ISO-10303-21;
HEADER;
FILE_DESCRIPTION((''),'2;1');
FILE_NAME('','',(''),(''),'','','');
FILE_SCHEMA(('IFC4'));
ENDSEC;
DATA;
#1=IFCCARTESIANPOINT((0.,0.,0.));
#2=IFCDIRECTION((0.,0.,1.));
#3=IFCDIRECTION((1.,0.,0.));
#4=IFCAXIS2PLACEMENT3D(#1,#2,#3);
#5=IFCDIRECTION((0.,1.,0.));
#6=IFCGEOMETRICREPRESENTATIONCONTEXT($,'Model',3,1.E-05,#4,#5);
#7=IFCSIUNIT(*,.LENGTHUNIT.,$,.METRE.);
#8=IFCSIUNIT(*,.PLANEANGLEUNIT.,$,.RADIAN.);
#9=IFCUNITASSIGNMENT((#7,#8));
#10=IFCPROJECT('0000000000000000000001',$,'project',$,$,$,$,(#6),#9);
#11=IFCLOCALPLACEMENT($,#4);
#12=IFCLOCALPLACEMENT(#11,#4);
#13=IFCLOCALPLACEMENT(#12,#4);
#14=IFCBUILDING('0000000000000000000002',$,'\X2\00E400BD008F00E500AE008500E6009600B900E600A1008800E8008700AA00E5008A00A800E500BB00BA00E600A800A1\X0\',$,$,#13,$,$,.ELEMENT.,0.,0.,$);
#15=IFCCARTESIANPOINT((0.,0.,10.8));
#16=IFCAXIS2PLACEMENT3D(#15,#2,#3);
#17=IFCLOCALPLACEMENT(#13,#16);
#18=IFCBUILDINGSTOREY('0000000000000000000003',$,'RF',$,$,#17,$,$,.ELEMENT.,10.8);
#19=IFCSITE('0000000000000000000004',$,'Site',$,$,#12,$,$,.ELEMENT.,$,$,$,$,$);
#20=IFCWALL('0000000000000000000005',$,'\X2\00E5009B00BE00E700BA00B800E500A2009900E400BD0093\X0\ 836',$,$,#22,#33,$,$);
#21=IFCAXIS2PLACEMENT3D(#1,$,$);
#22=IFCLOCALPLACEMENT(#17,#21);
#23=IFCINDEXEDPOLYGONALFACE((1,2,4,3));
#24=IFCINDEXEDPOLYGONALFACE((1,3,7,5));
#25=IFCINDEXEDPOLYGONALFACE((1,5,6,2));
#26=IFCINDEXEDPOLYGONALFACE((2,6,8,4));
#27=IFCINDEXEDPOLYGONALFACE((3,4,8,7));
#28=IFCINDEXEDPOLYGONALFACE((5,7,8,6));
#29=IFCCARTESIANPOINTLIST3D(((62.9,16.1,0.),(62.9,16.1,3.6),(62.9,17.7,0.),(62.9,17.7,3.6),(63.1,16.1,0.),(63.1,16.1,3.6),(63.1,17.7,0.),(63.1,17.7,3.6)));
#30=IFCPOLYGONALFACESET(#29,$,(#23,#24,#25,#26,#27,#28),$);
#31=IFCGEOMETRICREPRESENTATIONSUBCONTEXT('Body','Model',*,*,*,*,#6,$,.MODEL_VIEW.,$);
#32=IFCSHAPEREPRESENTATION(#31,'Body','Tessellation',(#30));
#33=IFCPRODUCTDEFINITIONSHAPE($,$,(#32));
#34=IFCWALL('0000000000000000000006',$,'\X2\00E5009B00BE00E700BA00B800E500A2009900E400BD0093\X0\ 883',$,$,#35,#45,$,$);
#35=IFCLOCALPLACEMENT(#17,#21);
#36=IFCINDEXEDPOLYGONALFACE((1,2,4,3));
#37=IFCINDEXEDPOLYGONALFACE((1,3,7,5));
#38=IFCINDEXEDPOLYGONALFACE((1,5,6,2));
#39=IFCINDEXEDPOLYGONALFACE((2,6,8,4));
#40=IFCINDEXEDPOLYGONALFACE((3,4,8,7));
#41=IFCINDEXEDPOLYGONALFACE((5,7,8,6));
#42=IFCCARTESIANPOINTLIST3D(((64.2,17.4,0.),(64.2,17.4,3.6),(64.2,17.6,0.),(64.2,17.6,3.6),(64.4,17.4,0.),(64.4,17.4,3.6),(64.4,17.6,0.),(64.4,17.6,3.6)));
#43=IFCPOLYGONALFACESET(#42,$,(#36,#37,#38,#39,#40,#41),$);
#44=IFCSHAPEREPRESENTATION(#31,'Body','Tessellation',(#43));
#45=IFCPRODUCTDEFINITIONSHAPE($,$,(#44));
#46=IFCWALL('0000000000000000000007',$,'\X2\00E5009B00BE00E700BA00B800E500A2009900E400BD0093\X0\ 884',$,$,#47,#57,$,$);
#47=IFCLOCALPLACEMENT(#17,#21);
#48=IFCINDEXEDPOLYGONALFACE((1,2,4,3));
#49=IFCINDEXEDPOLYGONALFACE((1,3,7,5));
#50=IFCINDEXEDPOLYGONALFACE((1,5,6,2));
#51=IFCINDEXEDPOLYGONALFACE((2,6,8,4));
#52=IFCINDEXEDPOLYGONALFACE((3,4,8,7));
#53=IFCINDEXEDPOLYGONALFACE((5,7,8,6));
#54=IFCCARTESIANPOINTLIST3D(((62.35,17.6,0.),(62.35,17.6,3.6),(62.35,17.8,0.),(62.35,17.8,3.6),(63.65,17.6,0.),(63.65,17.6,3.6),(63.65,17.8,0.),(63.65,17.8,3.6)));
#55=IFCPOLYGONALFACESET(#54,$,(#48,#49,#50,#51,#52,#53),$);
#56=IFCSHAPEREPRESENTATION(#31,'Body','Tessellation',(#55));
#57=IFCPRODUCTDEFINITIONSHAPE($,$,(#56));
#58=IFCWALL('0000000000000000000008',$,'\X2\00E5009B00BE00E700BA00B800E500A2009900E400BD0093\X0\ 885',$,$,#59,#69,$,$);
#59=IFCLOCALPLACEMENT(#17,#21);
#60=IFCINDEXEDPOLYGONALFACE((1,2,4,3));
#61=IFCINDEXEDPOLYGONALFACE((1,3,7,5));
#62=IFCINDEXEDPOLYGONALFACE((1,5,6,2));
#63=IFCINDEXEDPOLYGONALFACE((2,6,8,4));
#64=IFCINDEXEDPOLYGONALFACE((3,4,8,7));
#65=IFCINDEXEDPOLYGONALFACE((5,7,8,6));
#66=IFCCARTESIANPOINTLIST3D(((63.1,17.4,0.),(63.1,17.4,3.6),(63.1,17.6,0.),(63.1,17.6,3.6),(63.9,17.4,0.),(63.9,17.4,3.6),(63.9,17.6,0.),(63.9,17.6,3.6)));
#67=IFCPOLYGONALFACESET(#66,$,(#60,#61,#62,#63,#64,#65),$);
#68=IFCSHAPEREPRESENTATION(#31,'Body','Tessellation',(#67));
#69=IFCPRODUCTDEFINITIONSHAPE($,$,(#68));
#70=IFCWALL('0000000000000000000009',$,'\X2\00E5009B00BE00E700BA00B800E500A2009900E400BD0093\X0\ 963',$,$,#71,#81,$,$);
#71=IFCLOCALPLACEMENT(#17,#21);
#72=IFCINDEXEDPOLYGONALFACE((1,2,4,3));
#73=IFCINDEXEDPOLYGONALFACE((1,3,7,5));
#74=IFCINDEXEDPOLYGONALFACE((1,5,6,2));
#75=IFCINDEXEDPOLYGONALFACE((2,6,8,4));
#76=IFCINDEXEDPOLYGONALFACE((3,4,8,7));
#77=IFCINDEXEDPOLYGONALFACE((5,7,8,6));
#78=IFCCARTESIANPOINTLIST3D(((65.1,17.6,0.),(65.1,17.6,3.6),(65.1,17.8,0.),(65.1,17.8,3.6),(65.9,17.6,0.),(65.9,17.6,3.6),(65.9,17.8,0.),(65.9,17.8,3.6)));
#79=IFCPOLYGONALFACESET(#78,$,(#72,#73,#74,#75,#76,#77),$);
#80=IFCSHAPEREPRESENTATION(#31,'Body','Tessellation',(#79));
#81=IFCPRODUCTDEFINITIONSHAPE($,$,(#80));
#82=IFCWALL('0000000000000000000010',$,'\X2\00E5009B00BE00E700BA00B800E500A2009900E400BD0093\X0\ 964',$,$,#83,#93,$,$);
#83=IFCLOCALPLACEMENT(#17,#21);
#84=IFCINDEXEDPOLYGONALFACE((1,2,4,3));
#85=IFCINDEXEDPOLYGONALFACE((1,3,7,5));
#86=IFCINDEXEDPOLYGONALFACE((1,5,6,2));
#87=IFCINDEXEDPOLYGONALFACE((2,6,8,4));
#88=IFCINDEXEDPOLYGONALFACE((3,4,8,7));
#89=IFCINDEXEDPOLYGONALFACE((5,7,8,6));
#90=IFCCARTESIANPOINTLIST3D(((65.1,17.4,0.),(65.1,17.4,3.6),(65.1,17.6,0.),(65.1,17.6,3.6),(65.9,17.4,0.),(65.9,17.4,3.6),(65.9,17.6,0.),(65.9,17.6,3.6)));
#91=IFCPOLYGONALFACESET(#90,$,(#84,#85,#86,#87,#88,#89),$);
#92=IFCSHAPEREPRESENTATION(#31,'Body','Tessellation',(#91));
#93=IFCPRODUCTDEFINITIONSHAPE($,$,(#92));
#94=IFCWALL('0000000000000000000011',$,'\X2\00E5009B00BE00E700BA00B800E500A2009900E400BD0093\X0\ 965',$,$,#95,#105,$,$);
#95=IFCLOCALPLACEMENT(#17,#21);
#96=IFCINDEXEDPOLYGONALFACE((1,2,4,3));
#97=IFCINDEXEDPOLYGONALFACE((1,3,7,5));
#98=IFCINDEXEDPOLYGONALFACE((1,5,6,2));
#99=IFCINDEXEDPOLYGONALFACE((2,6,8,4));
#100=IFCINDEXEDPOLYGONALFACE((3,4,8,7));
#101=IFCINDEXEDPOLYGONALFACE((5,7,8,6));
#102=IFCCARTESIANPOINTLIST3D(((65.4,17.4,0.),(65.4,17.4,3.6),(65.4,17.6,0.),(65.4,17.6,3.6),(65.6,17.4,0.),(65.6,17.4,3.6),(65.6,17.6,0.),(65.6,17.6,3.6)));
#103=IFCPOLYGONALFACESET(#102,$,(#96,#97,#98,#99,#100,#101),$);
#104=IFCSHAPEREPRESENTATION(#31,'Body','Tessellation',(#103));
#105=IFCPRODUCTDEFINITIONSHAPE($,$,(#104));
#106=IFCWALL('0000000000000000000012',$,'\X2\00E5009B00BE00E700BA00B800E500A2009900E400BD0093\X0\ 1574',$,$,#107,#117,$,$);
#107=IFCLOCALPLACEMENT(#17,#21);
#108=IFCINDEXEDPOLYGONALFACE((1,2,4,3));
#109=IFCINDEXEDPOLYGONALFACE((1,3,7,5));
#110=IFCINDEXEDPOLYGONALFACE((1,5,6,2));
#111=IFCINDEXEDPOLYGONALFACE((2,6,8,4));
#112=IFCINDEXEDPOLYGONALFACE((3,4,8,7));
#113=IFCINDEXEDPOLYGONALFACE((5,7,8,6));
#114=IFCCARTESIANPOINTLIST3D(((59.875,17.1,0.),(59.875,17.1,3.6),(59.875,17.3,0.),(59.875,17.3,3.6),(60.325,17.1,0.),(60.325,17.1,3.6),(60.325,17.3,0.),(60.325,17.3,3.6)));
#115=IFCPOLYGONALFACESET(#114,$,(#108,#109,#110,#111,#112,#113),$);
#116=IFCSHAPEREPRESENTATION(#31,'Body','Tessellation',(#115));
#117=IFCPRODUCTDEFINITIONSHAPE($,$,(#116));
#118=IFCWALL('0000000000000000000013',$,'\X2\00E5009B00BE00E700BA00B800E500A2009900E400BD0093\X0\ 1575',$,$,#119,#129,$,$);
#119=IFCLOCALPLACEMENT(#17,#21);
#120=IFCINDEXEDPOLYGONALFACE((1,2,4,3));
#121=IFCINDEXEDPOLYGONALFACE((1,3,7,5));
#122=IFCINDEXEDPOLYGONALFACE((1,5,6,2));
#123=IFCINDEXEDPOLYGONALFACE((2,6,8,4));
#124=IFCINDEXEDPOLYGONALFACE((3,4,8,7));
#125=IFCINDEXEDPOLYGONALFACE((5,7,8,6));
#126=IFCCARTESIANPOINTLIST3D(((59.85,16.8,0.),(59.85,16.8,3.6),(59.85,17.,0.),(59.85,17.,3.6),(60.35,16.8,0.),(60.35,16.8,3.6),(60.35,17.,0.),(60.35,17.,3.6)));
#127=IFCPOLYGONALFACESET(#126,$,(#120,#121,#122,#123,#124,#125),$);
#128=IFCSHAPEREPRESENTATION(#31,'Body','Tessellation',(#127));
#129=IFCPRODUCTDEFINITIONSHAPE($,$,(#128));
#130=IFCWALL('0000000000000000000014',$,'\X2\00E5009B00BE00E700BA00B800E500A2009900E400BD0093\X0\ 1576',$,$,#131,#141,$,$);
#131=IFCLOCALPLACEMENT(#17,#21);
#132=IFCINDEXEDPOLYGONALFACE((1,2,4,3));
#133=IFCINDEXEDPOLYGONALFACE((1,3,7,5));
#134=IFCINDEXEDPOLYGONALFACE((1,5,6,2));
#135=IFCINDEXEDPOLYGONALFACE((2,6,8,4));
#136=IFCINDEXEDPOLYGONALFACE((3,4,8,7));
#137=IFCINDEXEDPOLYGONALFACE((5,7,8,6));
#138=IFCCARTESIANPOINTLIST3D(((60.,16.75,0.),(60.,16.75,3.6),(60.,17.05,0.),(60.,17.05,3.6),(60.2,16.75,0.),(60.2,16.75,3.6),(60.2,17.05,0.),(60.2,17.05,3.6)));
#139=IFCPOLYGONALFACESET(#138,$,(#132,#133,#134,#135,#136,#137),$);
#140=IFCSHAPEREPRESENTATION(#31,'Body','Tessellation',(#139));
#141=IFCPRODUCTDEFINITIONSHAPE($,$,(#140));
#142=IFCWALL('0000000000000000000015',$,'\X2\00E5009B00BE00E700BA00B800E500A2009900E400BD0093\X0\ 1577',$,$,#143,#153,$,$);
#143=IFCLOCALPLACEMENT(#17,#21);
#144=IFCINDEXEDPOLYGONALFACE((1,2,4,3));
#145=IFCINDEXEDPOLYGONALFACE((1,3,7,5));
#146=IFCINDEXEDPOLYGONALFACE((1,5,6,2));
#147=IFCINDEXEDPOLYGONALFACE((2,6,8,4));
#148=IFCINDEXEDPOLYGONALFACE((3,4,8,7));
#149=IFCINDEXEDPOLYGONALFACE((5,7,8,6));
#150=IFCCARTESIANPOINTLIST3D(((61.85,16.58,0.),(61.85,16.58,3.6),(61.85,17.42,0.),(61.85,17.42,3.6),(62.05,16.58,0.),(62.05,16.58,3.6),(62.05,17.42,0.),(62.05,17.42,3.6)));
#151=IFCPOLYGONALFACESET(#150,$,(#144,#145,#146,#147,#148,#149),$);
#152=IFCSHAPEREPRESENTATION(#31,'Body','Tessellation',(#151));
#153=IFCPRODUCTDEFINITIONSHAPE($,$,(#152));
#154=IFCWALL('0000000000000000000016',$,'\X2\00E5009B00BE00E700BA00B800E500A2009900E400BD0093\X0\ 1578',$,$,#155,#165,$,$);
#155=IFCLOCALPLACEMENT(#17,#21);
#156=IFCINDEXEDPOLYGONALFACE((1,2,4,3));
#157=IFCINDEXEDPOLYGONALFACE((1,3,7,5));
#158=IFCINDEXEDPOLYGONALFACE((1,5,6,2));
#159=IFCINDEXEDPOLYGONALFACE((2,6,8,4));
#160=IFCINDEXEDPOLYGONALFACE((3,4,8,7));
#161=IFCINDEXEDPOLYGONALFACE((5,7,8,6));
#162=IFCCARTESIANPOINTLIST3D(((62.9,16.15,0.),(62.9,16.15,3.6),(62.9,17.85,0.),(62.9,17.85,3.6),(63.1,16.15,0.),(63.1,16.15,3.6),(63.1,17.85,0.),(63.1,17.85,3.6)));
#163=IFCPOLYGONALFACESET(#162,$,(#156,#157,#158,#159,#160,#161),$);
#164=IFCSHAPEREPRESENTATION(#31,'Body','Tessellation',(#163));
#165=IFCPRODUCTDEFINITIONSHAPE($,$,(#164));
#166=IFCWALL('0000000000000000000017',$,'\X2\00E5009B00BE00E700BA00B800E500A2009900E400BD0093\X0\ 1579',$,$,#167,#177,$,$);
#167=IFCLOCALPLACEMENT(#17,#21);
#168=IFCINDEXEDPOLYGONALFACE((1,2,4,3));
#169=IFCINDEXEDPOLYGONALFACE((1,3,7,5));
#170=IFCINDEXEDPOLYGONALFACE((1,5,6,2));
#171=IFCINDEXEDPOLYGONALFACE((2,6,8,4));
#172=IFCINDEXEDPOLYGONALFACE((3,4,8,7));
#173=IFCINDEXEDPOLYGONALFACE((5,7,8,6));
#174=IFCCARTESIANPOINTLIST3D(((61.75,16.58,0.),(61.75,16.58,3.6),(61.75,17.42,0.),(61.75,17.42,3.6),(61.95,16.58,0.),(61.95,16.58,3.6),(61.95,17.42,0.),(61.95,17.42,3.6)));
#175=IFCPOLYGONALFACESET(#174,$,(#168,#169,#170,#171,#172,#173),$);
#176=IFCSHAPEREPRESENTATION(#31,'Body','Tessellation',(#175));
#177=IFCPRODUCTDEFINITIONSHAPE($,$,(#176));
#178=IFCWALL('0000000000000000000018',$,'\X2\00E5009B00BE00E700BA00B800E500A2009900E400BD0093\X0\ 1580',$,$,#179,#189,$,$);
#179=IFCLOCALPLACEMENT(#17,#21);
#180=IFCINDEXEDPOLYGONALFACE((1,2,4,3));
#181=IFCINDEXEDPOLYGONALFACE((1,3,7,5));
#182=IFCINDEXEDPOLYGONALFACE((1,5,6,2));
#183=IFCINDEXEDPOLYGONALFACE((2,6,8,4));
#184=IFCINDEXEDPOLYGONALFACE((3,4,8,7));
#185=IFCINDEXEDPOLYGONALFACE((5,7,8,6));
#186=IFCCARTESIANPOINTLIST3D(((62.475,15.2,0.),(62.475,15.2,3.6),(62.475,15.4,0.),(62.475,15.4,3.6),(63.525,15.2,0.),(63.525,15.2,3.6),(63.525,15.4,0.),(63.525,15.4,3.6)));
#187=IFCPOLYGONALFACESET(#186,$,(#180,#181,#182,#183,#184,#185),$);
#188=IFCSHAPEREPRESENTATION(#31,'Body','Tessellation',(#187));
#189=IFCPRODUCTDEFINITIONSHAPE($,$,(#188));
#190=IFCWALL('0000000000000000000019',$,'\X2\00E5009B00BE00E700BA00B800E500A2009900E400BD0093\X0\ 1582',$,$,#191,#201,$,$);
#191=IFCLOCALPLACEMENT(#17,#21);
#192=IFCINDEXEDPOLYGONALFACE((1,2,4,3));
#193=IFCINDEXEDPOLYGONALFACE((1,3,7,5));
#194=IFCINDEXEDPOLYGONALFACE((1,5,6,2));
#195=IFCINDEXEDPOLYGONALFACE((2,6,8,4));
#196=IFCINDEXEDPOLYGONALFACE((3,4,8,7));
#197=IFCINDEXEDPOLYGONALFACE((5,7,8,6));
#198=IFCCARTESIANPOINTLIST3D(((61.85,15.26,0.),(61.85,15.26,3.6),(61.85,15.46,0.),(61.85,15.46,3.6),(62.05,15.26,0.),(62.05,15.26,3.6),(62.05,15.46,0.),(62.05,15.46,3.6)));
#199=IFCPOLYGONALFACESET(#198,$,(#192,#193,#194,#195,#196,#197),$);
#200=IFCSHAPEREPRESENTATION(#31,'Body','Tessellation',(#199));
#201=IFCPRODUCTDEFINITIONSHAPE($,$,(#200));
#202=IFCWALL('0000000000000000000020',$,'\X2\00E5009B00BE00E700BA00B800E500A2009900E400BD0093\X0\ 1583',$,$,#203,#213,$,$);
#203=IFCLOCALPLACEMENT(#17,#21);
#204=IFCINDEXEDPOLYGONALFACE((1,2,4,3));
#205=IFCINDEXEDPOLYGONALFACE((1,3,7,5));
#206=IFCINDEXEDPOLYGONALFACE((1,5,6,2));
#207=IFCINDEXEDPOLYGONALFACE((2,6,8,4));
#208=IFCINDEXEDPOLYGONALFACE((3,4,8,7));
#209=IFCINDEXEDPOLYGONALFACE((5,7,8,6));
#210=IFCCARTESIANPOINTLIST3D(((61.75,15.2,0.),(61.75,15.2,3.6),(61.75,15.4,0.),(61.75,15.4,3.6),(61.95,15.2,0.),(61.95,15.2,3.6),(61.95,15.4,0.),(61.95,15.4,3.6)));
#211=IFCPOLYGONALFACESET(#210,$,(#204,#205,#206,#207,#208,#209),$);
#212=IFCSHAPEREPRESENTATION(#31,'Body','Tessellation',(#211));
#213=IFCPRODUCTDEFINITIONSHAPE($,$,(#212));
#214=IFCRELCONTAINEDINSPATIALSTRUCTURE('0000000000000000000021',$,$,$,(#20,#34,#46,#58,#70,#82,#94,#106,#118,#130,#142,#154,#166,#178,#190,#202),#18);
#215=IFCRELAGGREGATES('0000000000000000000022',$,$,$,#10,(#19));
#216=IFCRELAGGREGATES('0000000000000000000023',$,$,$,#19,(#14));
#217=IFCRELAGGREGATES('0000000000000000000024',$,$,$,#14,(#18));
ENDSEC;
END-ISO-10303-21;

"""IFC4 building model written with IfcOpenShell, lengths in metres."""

from ifc_helpers import new_model, si_unit, direction, frame, frame_2d, origin_with_axes, place, context, subcontext, project, spatial, rectangle, extrude, element, save


model = new_model("IFC4")

# Units and contexts
model_context = context("Model", 3, precision=1e-05, world=origin_with_axes(), true_north=direction((0.0, 1.0, 0.0)))
body_context = subcontext(model_context, "Body", "Model", "MODEL_VIEW")
ifc_project = project(units=[si_unit("LENGTHUNIT", "METRE"), si_unit("PLANEANGLEUNIT", "RADIAN")], contexts=[model_context])

# Site, building, storey
placement = place(None, origin_with_axes())
site_placement = place(placement, origin_with_axes())
site = spatial("IfcSite", under=ifc_project, at=site_placement, Name="Site", CompositionType="ELEMENT")
building_placement = place(site_placement, origin_with_axes())
building = spatial("IfcBuilding", under=site, at=building_placement, Name="ä½\u008få®\u0085æ\u0096¹æ¡\u0088è\u0087ªå\u008a¨å»ºæ¨¡", CompositionType="ELEMENT", ElevationOfRefHeight=0.0, ElevationOfTerrain=0.0)
storey_placement = place(building_placement, frame((0.0, 0.0, 10.8), z_axis=(0.0, 0.0, 1.0), x_axis=(1.0, 0.0, 0.0)))
storey = spatial("IfcBuildingStorey", under=building, at=storey_placement, Name="RF", CompositionType="ELEMENT", Elevation=10.8)

# Walls
wall_1_placement = place(storey_placement, frame((63.0, 16.9, 0.0), z_axis=(0.0, 0.0, 1.0), x_axis=(0.0, -1.0, 0.0)))
element("IfcWall", 1, at=wall_1_placement, inside=storey, Name="å\u009b¾çº¸å¢\u0099ä½\u0093 836", context=body_context, shape_type="SweptSolid", body=[
    extrude(rectangle(XDim=1.6, YDim=0.2, at=frame_2d((0.0, 0.0), x_axis=(1.0, 0.0, 0.0))), frame((0.0, 0.0, 0.0), z_axis=(0.0, 0.0, 1.0)), (0.0, 0.0, 1.0), 3.6),
])
wall_2_placement = place(storey_placement, frame((64.3, 17.5, 0.0), z_axis=(0.0, 0.0, 1.0), x_axis=(0.0, 1.0, 0.0)))
element("IfcWall", 2, at=wall_2_placement, inside=storey, Name="å\u009b¾çº¸å¢\u0099ä½\u0093 883", context=body_context, shape_type="SweptSolid", body=[
    extrude(rectangle(XDim=0.2, YDim=0.2, at=frame_2d((0.0, 0.0), x_axis=(1.0, 0.0, 0.0))), frame((0.0, 0.0, 0.0), z_axis=(0.0, 0.0, 1.0)), (0.0, 0.0, 1.0), 3.6),
])
wall_3_placement = place(storey_placement, frame((63.0, 17.7, 0.0), z_axis=(0.0, 0.0, 1.0), x_axis=(1.0, 0.0, 0.0)))
element("IfcWall", 3, at=wall_3_placement, inside=storey, Name="å\u009b¾çº¸å¢\u0099ä½\u0093 884", context=body_context, shape_type="SweptSolid", body=[
    extrude(rectangle(XDim=1.3, YDim=0.2, at=frame_2d((0.0, 0.0), x_axis=(1.0, 0.0, 0.0))), frame((0.0, 0.0, 0.0), z_axis=(0.0, 0.0, 1.0)), (0.0, 0.0, 1.0), 3.6),
])
for number, where, z_axis, x_axis, name in (
    (4, (63.5, 17.5, 0.0), (0.0, 0.0, 1.0), (1.0, 0.0, 0.0), "å\u009b¾çº¸å¢\u0099ä½\u0093 885"),
    (5, (65.5, 17.7, 0.0), (0.0, 0.0, 1.0), (1.0, 0.0, 0.0), "å\u009b¾çº¸å¢\u0099ä½\u0093 963"),
    (6, (65.5, 17.5, 0.0), (0.0, 0.0, 1.0), (1.0, 0.0, 0.0), "å\u009b¾çº¸å¢\u0099ä½\u0093 964"),
):
    element("IfcWall", number, at=place(storey_placement, frame(where, z_axis=z_axis, x_axis=x_axis)), inside=storey, Name=name, context=body_context, shape_type="SweptSolid", body=[
        extrude(rectangle(XDim=0.8, YDim=0.2, at=frame_2d((0.0, 0.0), x_axis=(1.0, 0.0, 0.0))), frame((0.0, 0.0, 0.0), z_axis=(0.0, 0.0, 1.0)), (0.0, 0.0, 1.0), 3.6),
    ])
wall_4_placement = place(storey_placement, frame((65.5, 17.5, 0.0), z_axis=(0.0, 0.0, 1.0), x_axis=(0.0, 1.0, 0.0)))
element("IfcWall", 7, at=wall_4_placement, inside=storey, Name="å\u009b¾çº¸å¢\u0099ä½\u0093 965", context=body_context, shape_type="SweptSolid", body=[
    extrude(rectangle(XDim=0.2, YDim=0.2, at=frame_2d((0.0, 0.0), x_axis=(1.0, 0.0, 0.0))), frame((0.0, 0.0, 0.0), z_axis=(0.0, 0.0, 1.0)), (0.0, 0.0, 1.0), 3.6),
])
wall_5_placement = place(storey_placement, frame((60.1, 17.2, 0.0), z_axis=(0.0, 0.0, 1.0), x_axis=(-1.0, 0.0, 0.0)))
element("IfcWall", 8, at=wall_5_placement, inside=storey, Name="å\u009b¾çº¸å¢\u0099ä½\u0093 1574", context=body_context, shape_type="SweptSolid", body=[
    extrude(rectangle(XDim=0.45, YDim=0.2, at=frame_2d((0.0, 0.0), x_axis=(1.0, 0.0, 0.0))), frame((0.0, 0.0, 0.0), z_axis=(0.0, 0.0, 1.0)), (0.0, 0.0, 1.0), 3.6),
])
wall_6_placement = place(storey_placement, frame((60.1, 16.9, 0.0), z_axis=(0.0, 0.0, 1.0), x_axis=(-1.0, 0.0, 0.0)))
element("IfcWall", 9, at=wall_6_placement, inside=storey, Name="å\u009b¾çº¸å¢\u0099ä½\u0093 1575", context=body_context, shape_type="SweptSolid", body=[
    extrude(rectangle(XDim=0.5, YDim=0.2, at=frame_2d((0.0, 0.0), x_axis=(1.0, 0.0, 0.0))), frame((0.0, 0.0, 0.0), z_axis=(0.0, 0.0, 1.0)), (0.0, 0.0, 1.0), 3.6),
])
wall_7_placement = place(storey_placement, frame((60.1, 16.9, 0.0), z_axis=(0.0, 0.0, 1.0), x_axis=(0.0, 1.0, 0.0)))
element("IfcWall", 10, at=wall_7_placement, inside=storey, Name="å\u009b¾çº¸å¢\u0099ä½\u0093 1576", context=body_context, shape_type="SweptSolid", body=[
    extrude(rectangle(XDim=0.3, YDim=0.2, at=frame_2d((0.0, 0.0), x_axis=(1.0, 0.0, 0.0))), frame((0.0, 0.0, 0.0), z_axis=(0.0, 0.0, 1.0)), (0.0, 0.0, 1.0), 3.6),
])
wall_8_placement = place(storey_placement, frame((61.95, 17.0, 0.0), z_axis=(0.0, 0.0, 1.0), x_axis=(0.0, -1.0, 0.0)))
element("IfcWall", 11, at=wall_8_placement, inside=storey, Name="å\u009b¾çº¸å¢\u0099ä½\u0093 1577", context=body_context, shape_type="SweptSolid", body=[
    extrude(rectangle(XDim=0.84, YDim=0.2, at=frame_2d((0.0, 0.0), x_axis=(1.0, 0.0, 0.0))), frame((0.0, 0.0, 0.0), z_axis=(0.0, 0.0, 1.0)), (0.0, 0.0, 1.0), 3.6),
])
wall_9_placement = place(storey_placement, frame((63.0, 17.0, 0.0), z_axis=(0.0, 0.0, 1.0), x_axis=(0.0, -1.0, 0.0)))
element("IfcWall", 12, at=wall_9_placement, inside=storey, Name="å\u009b¾çº¸å¢\u0099ä½\u0093 1578", context=body_context, shape_type="SweptSolid", body=[
    extrude(rectangle(XDim=1.7, YDim=0.2, at=frame_2d((0.0, 0.0), x_axis=(1.0, 0.0, 0.0))), frame((0.0, 0.0, 0.0), z_axis=(0.0, 0.0, 1.0)), (0.0, 0.0, 1.0), 3.6),
])
wall_10_placement = place(storey_placement, frame((61.85, 17.0, 0.0), z_axis=(0.0, 0.0, 1.0), x_axis=(0.0, -1.0, 0.0)))
element("IfcWall", 13, at=wall_10_placement, inside=storey, Name="å\u009b¾çº¸å¢\u0099ä½\u0093 1579", context=body_context, shape_type="SweptSolid", body=[
    extrude(rectangle(XDim=0.84, YDim=0.2, at=frame_2d((0.0, 0.0), x_axis=(1.0, 0.0, 0.0))), frame((0.0, 0.0, 0.0), z_axis=(0.0, 0.0, 1.0)), (0.0, 0.0, 1.0), 3.6),
])
wall_11_placement = place(storey_placement, frame((63.0, 15.3, 0.0), z_axis=(0.0, 0.0, 1.0), x_axis=(-1.0, 0.0, 0.0)))
element("IfcWall", 14, at=wall_11_placement, inside=storey, Name="å\u009b¾çº¸å¢\u0099ä½\u0093 1580", context=body_context, shape_type="SweptSolid", body=[
    extrude(rectangle(XDim=1.05, YDim=0.2, at=frame_2d((0.0, 0.0), x_axis=(1.0, 0.0, 0.0))), frame((0.0, 0.0, 0.0), z_axis=(0.0, 0.0, 1.0)), (0.0, 0.0, 1.0), 3.6),
])
for number, where, z_axis, x_axis, name in (
    (15, (61.95, 15.36, 0.0), (0.0, 0.0, 1.0), (0.0, -1.0, 0.0), "å\u009b¾çº¸å¢\u0099ä½\u0093 1582"),
    (16, (61.85, 15.3, 0.0), (0.0, 0.0, 1.0), (0.0, -1.0, 0.0), "å\u009b¾çº¸å¢\u0099ä½\u0093 1583"),
):
    element("IfcWall", number, at=place(storey_placement, frame(where, z_axis=z_axis, x_axis=x_axis)), inside=storey, Name=name, context=body_context, shape_type="SweptSolid", body=[
        extrude(rectangle(XDim=0.2, YDim=0.2, at=frame_2d((0.0, 0.0), x_axis=(1.0, 0.0, 0.0))), frame((0.0, 0.0, 0.0), z_axis=(0.0, 0.0, 1.0)), (0.0, 0.0, 1.0), 3.6),
    ])

save(model, "model.ifc")
